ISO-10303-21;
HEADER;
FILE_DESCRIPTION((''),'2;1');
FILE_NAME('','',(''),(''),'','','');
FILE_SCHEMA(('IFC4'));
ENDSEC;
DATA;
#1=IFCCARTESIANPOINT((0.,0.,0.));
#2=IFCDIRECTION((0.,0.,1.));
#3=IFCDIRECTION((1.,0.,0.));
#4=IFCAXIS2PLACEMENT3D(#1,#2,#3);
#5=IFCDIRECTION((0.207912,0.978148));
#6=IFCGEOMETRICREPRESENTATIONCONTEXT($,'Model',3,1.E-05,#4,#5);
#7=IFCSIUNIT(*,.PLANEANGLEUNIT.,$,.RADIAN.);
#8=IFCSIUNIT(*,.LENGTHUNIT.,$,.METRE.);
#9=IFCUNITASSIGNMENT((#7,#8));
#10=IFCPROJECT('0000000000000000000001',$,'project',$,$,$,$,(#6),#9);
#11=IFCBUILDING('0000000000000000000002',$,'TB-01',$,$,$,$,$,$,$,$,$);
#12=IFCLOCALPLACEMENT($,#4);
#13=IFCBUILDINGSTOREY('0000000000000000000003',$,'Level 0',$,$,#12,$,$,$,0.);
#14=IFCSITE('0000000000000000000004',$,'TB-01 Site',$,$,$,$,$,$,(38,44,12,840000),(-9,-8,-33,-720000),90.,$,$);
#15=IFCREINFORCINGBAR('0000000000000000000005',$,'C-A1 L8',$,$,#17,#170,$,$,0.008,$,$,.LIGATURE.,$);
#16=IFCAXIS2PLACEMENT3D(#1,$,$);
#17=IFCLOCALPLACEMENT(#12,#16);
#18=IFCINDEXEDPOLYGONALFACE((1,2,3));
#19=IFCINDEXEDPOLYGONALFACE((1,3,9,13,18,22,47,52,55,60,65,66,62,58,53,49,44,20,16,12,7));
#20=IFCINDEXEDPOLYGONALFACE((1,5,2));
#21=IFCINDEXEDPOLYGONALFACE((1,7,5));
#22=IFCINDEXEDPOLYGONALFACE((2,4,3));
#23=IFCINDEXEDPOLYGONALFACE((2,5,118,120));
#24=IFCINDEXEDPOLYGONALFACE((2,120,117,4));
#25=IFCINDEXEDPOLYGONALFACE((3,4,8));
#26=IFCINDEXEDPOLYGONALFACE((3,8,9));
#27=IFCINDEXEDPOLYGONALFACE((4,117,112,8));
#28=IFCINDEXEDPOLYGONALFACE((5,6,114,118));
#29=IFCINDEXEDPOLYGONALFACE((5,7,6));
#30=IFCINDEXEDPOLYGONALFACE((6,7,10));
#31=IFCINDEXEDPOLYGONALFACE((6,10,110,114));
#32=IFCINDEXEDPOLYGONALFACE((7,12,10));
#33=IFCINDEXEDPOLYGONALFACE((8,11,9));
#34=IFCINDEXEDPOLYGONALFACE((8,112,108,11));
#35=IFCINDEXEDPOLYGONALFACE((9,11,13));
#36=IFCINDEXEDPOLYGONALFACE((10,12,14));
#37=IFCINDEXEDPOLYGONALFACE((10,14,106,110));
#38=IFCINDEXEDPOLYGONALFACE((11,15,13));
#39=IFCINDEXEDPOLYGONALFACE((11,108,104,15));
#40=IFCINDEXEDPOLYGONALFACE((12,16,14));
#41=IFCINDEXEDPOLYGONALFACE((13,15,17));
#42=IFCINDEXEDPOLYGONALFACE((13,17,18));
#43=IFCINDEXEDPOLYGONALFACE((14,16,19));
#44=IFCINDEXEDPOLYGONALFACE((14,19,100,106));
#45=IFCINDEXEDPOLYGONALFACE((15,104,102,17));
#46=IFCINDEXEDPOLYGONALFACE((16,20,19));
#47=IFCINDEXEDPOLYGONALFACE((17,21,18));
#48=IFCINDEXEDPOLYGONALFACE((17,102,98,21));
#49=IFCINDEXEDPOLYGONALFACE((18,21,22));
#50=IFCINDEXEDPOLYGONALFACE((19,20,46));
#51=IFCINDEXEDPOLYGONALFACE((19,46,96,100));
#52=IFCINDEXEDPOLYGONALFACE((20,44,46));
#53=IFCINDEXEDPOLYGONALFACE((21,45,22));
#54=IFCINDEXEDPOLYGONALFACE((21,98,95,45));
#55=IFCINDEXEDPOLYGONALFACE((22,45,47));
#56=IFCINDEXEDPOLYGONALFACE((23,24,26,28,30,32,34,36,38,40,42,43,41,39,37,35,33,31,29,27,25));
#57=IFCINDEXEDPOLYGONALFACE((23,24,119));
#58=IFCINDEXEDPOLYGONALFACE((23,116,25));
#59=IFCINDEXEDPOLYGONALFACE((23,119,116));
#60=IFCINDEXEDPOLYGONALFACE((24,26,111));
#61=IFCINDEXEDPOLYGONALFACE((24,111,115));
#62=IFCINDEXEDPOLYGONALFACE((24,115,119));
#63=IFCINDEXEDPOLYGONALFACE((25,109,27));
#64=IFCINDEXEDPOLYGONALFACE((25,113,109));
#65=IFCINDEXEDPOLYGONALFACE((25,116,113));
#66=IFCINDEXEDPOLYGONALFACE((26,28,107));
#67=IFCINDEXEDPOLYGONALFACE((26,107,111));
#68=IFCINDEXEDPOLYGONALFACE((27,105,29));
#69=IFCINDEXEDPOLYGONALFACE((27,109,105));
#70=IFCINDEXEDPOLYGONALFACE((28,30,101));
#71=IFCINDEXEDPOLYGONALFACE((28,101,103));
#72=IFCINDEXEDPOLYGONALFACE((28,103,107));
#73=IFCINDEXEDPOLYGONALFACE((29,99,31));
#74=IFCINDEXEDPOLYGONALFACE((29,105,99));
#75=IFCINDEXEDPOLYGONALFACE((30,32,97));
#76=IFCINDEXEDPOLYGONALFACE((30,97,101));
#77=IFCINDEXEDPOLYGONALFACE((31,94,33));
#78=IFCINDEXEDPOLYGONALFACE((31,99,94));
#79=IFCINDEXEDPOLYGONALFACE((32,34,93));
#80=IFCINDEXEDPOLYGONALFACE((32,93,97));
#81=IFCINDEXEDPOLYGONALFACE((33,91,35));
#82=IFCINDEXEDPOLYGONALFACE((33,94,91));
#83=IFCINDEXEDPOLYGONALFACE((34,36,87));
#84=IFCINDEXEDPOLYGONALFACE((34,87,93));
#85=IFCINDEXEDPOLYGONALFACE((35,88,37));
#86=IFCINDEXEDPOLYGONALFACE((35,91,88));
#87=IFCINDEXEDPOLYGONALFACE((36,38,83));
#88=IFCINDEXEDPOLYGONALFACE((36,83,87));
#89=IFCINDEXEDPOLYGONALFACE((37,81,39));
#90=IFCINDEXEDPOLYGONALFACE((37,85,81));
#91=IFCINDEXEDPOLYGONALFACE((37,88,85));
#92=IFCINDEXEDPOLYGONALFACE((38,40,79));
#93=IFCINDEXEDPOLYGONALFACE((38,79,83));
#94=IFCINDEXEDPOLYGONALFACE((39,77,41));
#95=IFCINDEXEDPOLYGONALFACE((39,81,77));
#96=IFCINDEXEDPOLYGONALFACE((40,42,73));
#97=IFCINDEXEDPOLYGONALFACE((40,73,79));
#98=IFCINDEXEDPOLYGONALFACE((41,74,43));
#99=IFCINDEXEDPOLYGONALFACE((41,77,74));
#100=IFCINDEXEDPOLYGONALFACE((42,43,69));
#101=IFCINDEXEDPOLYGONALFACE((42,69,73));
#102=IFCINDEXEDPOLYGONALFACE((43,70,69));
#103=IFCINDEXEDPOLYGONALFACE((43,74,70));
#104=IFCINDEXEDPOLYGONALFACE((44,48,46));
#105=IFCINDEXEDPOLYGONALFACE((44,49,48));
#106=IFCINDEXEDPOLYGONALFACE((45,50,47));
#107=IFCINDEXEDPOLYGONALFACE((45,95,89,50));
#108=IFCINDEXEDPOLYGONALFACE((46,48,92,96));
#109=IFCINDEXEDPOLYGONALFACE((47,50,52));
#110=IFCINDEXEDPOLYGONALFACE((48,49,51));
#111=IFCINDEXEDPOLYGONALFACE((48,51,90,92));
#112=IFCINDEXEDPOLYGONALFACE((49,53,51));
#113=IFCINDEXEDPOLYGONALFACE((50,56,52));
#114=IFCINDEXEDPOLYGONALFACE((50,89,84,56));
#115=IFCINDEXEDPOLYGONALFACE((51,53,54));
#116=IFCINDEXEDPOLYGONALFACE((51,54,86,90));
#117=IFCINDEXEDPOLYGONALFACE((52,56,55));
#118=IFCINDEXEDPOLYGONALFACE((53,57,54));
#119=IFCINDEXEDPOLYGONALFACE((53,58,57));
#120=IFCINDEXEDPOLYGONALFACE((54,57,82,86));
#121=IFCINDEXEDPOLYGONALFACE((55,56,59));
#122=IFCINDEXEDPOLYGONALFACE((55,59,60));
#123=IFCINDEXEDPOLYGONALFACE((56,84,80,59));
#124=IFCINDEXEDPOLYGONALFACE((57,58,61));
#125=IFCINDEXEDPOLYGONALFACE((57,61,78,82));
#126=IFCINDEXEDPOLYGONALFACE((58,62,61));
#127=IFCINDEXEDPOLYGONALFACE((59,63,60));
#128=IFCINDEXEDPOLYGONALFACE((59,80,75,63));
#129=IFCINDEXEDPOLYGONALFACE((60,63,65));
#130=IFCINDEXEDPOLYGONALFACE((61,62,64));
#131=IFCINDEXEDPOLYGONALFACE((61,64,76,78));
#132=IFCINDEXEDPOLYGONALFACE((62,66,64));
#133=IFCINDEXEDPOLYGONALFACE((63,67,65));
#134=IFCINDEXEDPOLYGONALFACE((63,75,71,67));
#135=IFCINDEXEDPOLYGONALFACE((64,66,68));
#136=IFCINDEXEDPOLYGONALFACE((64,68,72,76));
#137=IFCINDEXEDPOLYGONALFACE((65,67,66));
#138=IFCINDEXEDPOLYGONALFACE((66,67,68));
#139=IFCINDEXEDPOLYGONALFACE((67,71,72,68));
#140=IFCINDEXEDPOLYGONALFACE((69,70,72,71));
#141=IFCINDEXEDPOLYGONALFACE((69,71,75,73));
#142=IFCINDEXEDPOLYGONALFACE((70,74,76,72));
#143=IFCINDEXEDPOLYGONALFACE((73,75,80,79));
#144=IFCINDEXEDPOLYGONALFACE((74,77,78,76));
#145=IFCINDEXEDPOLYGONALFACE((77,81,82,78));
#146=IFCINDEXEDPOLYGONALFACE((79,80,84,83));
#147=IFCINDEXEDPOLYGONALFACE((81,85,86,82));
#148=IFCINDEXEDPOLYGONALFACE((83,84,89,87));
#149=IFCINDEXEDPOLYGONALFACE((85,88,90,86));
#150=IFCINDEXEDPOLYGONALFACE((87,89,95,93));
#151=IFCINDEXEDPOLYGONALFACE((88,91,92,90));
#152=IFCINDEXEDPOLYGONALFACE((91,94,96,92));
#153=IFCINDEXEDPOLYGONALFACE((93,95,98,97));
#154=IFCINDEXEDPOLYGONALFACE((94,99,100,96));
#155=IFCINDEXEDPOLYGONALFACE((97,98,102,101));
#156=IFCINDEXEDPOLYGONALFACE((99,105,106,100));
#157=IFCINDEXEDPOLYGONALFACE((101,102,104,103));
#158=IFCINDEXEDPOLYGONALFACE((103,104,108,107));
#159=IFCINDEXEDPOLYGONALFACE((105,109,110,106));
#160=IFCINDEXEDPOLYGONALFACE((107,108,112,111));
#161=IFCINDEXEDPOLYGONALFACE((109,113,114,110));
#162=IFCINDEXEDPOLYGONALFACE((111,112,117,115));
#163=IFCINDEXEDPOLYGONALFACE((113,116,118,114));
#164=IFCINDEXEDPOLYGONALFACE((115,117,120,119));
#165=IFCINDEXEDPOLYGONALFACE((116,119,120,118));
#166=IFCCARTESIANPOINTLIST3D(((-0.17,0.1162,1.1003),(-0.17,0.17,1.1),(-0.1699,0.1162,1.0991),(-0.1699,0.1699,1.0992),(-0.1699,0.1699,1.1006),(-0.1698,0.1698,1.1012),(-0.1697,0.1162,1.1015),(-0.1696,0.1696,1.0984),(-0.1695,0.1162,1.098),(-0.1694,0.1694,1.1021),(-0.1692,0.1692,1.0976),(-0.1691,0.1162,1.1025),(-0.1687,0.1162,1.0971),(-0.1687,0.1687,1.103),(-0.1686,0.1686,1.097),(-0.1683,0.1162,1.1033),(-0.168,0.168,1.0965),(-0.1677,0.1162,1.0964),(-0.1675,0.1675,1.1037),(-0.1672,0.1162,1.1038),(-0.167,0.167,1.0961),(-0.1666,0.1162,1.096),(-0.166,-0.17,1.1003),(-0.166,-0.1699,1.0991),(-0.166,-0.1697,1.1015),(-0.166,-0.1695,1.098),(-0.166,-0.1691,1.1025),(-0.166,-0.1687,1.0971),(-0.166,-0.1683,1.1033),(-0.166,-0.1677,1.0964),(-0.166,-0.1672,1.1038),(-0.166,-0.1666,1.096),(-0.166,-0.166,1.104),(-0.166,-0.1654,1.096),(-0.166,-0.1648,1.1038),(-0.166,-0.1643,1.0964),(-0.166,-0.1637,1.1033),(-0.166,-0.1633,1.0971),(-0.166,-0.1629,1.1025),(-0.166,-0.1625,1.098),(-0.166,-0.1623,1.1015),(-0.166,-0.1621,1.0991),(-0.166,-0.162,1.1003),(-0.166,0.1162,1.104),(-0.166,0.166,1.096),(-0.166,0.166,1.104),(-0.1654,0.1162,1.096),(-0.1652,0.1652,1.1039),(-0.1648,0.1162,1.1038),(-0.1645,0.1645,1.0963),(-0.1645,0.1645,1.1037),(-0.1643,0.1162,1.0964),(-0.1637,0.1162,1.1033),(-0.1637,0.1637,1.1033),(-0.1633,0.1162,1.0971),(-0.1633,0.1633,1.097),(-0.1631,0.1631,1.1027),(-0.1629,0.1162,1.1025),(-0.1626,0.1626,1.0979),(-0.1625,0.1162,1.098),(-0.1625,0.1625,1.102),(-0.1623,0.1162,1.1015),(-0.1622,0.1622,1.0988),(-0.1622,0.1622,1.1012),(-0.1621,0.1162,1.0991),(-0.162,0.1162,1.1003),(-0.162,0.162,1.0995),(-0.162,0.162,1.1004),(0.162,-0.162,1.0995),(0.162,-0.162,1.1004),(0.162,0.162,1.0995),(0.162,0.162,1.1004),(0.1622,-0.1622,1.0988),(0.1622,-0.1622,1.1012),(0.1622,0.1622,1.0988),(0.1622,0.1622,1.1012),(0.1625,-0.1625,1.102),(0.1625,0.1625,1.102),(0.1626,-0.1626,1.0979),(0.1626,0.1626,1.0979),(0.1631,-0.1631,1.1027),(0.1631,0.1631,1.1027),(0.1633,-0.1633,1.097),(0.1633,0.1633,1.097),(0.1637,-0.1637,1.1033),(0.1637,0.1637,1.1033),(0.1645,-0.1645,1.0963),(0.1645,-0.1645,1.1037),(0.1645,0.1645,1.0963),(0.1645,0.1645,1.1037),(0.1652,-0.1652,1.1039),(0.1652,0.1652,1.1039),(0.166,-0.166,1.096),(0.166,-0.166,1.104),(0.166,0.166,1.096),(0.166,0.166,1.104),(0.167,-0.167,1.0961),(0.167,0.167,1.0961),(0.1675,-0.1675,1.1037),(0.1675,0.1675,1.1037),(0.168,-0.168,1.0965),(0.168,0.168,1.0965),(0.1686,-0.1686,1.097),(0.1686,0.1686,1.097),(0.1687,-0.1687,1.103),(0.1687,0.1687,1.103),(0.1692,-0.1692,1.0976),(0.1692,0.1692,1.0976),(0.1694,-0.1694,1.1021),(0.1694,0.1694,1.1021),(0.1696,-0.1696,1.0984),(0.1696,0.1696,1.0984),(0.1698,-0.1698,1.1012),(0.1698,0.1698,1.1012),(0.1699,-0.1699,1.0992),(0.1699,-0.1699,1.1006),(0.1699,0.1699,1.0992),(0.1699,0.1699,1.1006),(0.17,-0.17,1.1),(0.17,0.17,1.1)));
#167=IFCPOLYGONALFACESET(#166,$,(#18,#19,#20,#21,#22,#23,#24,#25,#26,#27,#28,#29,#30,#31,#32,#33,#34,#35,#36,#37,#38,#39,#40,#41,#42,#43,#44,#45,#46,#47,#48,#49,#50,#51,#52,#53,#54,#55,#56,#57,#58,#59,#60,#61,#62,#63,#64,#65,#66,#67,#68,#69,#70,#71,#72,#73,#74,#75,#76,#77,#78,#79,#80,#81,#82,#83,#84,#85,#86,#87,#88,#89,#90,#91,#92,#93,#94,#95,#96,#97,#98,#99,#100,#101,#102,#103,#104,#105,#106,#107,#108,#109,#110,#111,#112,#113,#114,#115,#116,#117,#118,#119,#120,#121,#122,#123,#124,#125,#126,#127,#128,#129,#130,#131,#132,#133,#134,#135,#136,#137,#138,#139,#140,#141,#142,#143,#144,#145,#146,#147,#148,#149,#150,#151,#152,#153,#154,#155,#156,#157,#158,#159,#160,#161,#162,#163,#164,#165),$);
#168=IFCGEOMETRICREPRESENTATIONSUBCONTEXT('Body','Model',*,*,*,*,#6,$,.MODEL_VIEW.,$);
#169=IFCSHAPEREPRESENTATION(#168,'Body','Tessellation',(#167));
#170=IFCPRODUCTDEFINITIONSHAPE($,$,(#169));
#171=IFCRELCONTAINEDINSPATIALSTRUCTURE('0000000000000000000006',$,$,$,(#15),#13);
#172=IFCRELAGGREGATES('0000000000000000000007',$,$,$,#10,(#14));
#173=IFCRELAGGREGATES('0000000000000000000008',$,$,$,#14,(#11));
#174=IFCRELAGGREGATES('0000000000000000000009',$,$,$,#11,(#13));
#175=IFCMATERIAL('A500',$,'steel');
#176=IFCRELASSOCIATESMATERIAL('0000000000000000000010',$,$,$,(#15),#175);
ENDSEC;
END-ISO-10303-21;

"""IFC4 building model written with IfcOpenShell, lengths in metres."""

from ifc_helpers import new_model, entity, si_unit, direction, origin_with_axes, place, context, subcontext, project, spatial, material, element, save


model = new_model("IFC4")

# Units and contexts
model_context = context("Model", 3, precision=1e-05, world=origin_with_axes(), true_north=direction((0.207912, 0.978148)))
body_context = subcontext(model_context, "Body", "Model", "MODEL_VIEW")
ifc_project = project(units=[si_unit("PLANEANGLEUNIT", "RADIAN"), si_unit("LENGTHUNIT", "METRE")], contexts=[model_context])

# Site, building, storey
site = spatial("IfcSite", under=ifc_project, Name="TB-01 Site", RefLatitude=(38, 44, 12, 840000), RefLongitude=(-9, -8, -33, -720000), RefElevation=90.0)
building = spatial("IfcBuilding", under=site, Name="TB-01")
storey_placement = place(None, origin_with_axes())
storey = spatial("IfcBuildingStorey", under=building, at=storey_placement, Name="Level 0", Elevation=0.0)

# Reinforcing bar
ifc_material_1 = material(Name="A500", Category="steel")
reinforcing_bar_1_placement = place(storey_placement, origin_with_axes())
element("IfcReinforcingBar", 1, at=reinforcing_bar_1_placement, inside=storey, material=ifc_material_1, Name="C-A1 L8", NominalDiameter=0.008, PredefinedType="LIGATURE", context=body_context, shape_type="AdvancedSweptSolid", body=[
    entity("IfcSweptDiskSolid", entity("IfcPolyline", [entity("IfcCartesianPoint", [-0.166, -0.166, 1.1]), entity("IfcCartesianPoint", [0.166, -0.166, 1.1]), entity("IfcCartesianPoint", [0.166, 0.166, 1.1]), entity("IfcCartesianPoint", [-0.166, 0.166, 1.1]), entity("IfcCartesianPoint", [-0.166, 0.1162, 1.1])]), 0.004),
])

save(model, "model.ifc")
